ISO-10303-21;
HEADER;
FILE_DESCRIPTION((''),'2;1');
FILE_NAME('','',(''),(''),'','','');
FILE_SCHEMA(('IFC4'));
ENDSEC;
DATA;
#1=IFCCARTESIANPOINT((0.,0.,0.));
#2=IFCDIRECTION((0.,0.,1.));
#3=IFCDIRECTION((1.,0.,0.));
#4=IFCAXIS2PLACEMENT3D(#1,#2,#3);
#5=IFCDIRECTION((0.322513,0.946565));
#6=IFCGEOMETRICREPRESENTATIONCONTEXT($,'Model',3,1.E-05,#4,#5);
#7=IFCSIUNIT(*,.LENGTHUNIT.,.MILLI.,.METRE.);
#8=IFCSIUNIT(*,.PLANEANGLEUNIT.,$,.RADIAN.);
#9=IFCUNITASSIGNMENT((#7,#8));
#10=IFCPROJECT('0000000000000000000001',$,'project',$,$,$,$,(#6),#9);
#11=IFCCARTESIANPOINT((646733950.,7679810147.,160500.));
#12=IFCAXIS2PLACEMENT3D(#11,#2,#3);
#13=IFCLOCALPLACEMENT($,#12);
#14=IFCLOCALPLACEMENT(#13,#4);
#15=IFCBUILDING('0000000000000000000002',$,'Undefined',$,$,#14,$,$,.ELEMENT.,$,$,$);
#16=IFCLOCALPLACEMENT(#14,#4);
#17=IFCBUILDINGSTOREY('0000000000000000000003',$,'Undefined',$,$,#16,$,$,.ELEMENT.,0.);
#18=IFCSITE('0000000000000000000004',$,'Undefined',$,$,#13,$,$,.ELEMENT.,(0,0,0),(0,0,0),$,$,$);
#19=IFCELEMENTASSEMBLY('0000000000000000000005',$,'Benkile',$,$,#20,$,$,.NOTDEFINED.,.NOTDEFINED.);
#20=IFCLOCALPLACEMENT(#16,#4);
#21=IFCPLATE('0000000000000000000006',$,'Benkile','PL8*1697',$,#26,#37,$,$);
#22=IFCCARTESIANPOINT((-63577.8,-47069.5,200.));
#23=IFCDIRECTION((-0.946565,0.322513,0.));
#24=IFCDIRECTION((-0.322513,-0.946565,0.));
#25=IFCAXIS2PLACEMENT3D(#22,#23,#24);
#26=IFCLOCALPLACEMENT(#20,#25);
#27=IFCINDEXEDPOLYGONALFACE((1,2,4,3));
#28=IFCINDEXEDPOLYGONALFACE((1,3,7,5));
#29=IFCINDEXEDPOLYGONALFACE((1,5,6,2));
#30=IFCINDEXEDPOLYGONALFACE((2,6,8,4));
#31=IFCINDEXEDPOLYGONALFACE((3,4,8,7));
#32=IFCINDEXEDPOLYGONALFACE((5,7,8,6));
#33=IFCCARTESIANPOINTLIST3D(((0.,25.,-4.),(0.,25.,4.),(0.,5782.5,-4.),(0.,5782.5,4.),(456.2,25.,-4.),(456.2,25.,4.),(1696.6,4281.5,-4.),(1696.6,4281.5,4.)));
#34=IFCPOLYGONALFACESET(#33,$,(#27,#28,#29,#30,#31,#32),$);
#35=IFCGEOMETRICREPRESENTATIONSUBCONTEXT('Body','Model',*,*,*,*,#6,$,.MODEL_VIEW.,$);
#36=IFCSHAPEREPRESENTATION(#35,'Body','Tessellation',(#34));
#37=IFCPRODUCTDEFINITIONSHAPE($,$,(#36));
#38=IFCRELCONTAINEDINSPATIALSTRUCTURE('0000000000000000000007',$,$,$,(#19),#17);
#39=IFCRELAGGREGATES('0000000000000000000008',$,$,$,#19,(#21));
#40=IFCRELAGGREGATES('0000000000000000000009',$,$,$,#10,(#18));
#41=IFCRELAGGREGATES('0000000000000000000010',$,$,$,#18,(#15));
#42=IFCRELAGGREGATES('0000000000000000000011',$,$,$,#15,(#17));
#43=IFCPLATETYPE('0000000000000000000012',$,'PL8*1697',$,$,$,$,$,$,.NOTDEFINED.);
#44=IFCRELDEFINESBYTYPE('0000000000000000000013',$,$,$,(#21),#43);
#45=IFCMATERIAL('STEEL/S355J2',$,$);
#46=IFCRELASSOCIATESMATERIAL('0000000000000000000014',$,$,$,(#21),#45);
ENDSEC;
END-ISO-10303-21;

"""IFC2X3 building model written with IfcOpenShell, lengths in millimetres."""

from ifc_helpers import new_model, si_unit, direction, frame, origin_with_axes, place, context, subcontext, project, spatial, polyline, outline, extrude, clip, halfspace, material, type_object, element, aggregate, save


model = new_model("IFC2X3")

# Units and contexts
model_context = context("Model", 3, precision=1e-05, world=origin_with_axes(), true_north=direction((0.322513, 0.946565)))
body_context = subcontext(model_context, "Body", "Model", "MODEL_VIEW")
ifc_project = project(units=[si_unit("LENGTHUNIT", "METRE", prefix="MILLI"), si_unit("PLANEANGLEUNIT", "RADIAN")], contexts=[model_context])

# Site, building, storey
site_placement = place(None, frame((646733950.0, 7679810147.0, 160500.0), z_axis=(0.0, 0.0, 1.0), x_axis=(1.0, 0.0, 0.0)))
site = spatial("IfcSite", under=ifc_project, at=site_placement, Name="Undefined", CompositionType="ELEMENT", RefLatitude=(0, 0, 0), RefLongitude=(0, 0, 0))
building_placement = place(site_placement, origin_with_axes())
building = spatial("IfcBuilding", under=site, at=building_placement, Name="Undefined", CompositionType="ELEMENT")
storey_placement = place(building_placement, origin_with_axes())
storey = spatial("IfcBuildingStorey", under=building, at=storey_placement, Name="Undefined", CompositionType="ELEMENT", Elevation=0.0)

# Shared definitions
ifc_material_1 = material(Name="STEEL/S355J2")

# Element assembly
assembly_1_placement = place(storey_placement, origin_with_axes())
assembly_1 = element("IfcElementAssembly", 1, at=assembly_1_placement, inside=storey, Name="Benkile", AssemblyPlace="NOTDEFINED", PredefinedType="NOTDEFINED")

# Plate
plate_type_1 = type_object("IfcPlateType", Name="PL8*1697", PredefinedType="NOTDEFINED")
plate_1_placement = place(assembly_1_placement, frame((-63577.8, -47069.5, 200.0), z_axis=(-0.946565, 0.322513, 0.0), x_axis=(-0.322513, -0.946565, 0.0)))
plate_1 = element("IfcPlate", 2, at=plate_1_placement, type_object=plate_type_1, material=ifc_material_1, Name="Benkile", Description="PL8*1697", context=body_context, shape_type="Clipping", body=[
    clip(extrude(outline(polyline([(0.0, 0.0), (449.0, 0.0), (1696.6, 4281.5), (0.0, 5782.5), (0.0, 0.0)])), frame((0.0, 0.0, -4.0), z_axis=(0.0, 0.0, 1.0), x_axis=(1.0, 0.0, 0.0)), (0.0, 0.0, 1.0), 8.0), halfspace(frame((0.0, 25.0, -4.0), z_axis=(0.0, -1.0, 0.0), x_axis=(0.0, 0.0, 1.0)), False)),
])

aggregate(assembly_1, [plate_1])

save(model, "model.ifc")
